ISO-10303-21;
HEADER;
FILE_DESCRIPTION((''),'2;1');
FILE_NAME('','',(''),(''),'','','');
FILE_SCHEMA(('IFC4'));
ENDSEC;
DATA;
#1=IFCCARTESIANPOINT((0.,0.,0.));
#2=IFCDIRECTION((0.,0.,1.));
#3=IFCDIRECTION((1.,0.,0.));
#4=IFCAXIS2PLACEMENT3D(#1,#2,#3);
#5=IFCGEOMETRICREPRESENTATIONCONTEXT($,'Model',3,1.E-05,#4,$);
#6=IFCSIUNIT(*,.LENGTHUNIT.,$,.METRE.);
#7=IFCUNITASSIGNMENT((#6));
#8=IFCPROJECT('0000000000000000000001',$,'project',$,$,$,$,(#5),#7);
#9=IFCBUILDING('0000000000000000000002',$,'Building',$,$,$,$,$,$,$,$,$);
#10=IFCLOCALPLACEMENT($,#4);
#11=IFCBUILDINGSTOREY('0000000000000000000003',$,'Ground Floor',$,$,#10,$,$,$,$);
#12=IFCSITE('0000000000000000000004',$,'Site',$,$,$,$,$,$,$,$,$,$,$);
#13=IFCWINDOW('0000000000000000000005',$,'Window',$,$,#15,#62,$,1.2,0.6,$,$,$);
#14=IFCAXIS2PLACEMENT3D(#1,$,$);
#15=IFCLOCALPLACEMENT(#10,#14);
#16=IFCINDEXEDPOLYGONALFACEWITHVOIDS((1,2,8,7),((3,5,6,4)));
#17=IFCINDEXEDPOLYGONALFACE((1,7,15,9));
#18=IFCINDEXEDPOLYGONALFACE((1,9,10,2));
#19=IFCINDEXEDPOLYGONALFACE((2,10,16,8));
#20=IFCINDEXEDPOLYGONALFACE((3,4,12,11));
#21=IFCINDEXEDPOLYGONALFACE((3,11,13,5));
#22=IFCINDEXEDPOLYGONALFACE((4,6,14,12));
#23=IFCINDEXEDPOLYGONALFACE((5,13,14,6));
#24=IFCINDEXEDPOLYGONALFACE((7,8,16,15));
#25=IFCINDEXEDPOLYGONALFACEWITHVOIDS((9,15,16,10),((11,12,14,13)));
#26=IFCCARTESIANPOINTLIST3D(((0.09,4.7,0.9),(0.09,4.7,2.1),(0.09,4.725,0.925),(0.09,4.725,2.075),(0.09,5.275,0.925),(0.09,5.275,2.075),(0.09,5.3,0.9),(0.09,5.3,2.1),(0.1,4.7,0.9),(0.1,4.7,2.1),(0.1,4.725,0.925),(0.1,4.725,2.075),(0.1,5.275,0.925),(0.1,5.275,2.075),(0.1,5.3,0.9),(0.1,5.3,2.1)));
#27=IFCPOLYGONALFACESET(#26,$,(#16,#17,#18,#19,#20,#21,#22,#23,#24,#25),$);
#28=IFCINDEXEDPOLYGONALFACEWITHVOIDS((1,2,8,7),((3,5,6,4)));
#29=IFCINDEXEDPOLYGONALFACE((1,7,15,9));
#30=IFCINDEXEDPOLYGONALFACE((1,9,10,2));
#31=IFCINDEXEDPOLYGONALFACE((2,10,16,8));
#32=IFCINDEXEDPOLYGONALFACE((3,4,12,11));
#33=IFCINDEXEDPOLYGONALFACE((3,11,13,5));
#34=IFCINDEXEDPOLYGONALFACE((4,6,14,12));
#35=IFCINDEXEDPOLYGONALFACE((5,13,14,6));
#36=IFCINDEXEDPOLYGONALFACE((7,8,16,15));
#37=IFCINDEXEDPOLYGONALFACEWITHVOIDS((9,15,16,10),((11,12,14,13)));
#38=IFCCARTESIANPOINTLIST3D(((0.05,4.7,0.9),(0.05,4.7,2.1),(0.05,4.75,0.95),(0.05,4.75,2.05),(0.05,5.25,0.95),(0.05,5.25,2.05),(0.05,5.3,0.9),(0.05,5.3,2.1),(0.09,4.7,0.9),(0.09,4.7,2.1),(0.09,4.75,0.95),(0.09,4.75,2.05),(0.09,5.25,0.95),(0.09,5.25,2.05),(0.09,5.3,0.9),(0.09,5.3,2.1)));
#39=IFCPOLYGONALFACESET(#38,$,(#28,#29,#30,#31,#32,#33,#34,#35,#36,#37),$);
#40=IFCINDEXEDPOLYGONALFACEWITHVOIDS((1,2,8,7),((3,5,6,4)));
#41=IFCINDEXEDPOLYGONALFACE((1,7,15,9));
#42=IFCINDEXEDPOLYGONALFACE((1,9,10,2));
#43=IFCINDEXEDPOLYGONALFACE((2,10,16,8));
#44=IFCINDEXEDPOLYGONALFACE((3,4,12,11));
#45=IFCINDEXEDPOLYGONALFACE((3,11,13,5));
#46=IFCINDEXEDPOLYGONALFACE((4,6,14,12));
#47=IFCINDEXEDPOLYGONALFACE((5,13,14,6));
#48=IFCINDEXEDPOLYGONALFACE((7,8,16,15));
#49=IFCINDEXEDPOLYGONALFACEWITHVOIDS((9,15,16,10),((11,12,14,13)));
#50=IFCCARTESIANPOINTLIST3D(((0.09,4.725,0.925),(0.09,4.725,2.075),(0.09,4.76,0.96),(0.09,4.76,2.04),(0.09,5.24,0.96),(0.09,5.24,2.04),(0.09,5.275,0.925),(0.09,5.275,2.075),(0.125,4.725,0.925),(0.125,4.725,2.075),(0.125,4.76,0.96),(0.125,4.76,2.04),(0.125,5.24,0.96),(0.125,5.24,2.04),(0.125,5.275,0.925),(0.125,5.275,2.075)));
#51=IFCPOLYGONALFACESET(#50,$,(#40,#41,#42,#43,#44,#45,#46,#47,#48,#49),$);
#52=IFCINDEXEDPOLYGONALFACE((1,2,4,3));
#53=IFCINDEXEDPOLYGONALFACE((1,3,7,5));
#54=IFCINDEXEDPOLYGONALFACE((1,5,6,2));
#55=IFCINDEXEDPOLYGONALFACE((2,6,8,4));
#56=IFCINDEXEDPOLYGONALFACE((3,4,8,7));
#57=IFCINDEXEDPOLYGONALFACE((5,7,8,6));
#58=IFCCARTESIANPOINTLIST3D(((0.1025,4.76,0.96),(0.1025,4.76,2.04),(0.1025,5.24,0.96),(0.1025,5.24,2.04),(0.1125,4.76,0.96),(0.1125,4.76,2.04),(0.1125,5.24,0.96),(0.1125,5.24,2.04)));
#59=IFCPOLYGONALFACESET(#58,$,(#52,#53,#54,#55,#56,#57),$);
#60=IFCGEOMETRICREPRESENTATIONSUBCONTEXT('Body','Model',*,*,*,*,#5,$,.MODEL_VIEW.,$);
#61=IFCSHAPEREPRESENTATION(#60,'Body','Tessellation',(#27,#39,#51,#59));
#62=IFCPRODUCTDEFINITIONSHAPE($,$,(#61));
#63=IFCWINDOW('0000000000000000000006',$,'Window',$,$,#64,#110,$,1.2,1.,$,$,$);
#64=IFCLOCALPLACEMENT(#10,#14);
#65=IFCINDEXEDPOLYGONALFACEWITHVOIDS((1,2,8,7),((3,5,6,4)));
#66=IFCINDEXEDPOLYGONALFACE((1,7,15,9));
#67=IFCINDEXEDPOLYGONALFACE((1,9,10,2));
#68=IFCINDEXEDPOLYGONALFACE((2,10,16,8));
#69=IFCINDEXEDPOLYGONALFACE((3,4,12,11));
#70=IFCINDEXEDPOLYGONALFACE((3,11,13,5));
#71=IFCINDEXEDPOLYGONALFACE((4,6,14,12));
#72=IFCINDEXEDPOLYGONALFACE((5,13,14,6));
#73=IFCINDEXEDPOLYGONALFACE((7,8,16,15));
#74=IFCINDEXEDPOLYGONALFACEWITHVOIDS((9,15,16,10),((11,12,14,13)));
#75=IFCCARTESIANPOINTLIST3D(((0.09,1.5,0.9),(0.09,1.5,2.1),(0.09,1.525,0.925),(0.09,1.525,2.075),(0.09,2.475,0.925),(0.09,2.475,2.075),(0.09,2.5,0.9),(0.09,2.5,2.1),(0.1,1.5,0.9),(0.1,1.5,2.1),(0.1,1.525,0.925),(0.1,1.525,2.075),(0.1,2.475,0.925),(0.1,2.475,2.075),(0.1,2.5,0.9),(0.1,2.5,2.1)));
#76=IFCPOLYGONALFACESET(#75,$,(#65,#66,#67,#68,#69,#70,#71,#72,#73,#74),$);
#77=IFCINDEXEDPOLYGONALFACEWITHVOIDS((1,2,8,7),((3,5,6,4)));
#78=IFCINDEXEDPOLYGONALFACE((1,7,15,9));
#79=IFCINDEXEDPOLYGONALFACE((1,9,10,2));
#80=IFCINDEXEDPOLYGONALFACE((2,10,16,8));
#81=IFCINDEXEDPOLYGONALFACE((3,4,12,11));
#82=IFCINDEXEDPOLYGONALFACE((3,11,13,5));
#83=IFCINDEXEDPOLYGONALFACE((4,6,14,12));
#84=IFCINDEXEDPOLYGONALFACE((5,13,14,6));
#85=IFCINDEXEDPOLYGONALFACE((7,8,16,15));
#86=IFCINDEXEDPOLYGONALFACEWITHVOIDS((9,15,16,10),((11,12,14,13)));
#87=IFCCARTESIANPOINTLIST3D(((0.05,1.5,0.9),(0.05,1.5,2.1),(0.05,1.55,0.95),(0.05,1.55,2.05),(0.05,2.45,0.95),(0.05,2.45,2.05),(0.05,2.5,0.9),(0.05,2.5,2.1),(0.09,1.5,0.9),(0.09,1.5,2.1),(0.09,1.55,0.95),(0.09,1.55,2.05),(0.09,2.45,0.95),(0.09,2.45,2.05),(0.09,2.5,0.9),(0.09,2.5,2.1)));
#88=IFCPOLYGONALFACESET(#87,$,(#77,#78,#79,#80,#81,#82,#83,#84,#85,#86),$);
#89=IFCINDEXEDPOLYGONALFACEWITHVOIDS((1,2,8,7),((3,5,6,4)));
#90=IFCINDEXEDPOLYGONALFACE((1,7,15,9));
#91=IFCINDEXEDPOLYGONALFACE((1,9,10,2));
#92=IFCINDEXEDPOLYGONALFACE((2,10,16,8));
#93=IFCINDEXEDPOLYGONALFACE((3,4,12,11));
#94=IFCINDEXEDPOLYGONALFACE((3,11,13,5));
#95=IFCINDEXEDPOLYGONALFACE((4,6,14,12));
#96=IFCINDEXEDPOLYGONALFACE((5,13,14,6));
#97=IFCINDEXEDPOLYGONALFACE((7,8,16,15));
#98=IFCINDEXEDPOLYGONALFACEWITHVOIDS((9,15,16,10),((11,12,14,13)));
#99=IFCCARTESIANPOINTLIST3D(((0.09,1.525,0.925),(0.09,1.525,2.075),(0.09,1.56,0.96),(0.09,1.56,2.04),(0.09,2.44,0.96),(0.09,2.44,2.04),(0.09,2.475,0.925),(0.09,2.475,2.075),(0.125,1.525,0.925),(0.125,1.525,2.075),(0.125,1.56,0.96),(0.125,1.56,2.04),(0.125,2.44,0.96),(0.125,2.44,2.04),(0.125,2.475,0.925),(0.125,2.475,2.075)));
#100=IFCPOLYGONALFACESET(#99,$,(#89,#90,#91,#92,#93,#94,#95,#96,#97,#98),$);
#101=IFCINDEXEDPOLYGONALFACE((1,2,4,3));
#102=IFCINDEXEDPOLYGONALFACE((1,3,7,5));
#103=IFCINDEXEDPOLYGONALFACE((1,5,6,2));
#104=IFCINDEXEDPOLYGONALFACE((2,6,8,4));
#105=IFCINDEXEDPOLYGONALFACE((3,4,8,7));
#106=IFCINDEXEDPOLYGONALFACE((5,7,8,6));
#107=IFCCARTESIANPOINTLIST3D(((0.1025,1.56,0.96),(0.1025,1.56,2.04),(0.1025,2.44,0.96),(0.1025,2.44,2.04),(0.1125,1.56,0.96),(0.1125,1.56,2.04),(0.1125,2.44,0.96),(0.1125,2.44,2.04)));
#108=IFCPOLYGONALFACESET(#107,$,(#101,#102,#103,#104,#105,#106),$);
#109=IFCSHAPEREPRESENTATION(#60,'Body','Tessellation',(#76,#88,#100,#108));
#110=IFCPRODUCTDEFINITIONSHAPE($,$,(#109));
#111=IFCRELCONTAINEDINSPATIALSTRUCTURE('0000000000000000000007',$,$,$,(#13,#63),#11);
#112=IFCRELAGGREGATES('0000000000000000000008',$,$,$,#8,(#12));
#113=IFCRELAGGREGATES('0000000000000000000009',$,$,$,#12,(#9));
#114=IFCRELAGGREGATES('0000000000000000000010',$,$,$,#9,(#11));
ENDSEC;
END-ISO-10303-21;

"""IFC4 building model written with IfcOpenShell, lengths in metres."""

from ifc_helpers import new_model, si_unit, frame, origin_with_axes, place, context, subcontext, project, spatial, line, indexed_curve, outline, extrude, element, save


model = new_model("IFC4")

# Units and contexts
model_context = context("Model", 3, precision=1e-05, world=origin_with_axes())
body_context = subcontext(model_context, "Body", "Model", "MODEL_VIEW")
ifc_project = project(units=[si_unit("LENGTHUNIT", "METRE")], contexts=[model_context])

# Site, building, storey
site = spatial("IfcSite", under=ifc_project, Name="Site")
building = spatial("IfcBuilding", under=site, Name="Building")
storey_placement = place(None, origin_with_axes())
storey = spatial("IfcBuildingStorey", under=building, at=storey_placement, Name="Ground Floor")

# Windows
window_1_placement = place(storey_placement, frame((0.0, 5.3, 0.9), z_axis=(0.0, 0.0, 1.0), x_axis=(0.0, -1.0, 0.0)))
element("IfcWindow", 1, at=window_1_placement, inside=storey, Name="Window", OverallHeight=1.2, OverallWidth=0.6, context=body_context, shape_type="SweptSolid", body=[
    extrude(outline(indexed_curve([(0.0, 0.0), (0.6, 0.0), (0.6, 1.2), (0.0, 1.2)], segments=[line(1, 2, 3, 4, 1)]), holes=[indexed_curve([(0.025, 0.025), (0.575, 0.025), (0.575, 1.175), (0.025, 1.175)], segments=[line(1, 2, 3, 4, 1)])]), frame((0.0, 0.09, 0.0), z_axis=(0.0, -1.0, 0.0), x_axis=(1.0, 0.0, 0.0)), (0.0, 0.0, -1.0), 0.01),
    extrude(outline(indexed_curve([(0.0, 0.0), (0.6, 0.0), (0.6, 1.2), (0.0, 1.2)], segments=[line(1, 2, 3, 4, 1)]), holes=[indexed_curve([(0.05, 0.05), (0.55, 0.05), (0.55, 1.15), (0.05, 1.15)], segments=[line(1, 2, 3, 4, 1)])]), frame((0.0, 0.05, 0.0), z_axis=(0.0, -1.0, 0.0), x_axis=(1.0, 0.0, 0.0)), (0.0, 0.0, -1.0), 0.04),
    extrude(outline(indexed_curve([(0.0, 0.0), (0.55, 0.0), (0.55, 1.15), (0.0, 1.15)], segments=[line(1, 2, 3, 4, 1)]), holes=[indexed_curve([(0.035, 0.035), (0.515, 0.035), (0.515, 1.115), (0.035, 1.115)], segments=[line(1, 2, 3, 4, 1)])]), frame((0.025, 0.09, 0.025), z_axis=(0.0, -1.0, 0.0), x_axis=(1.0, 0.0, 0.0)), (0.0, 0.0, -1.0), 0.035),
    extrude(outline(indexed_curve([(0.035, 0.035), (0.515, 0.035), (0.515, 1.115), (0.035, 1.115)], segments=[line(1, 2, 3, 4, 1)])), frame((0.025, 0.1025, 0.025), z_axis=(0.0, -1.0, 0.0), x_axis=(1.0, 0.0, 0.0)), (0.0, 0.0, -1.0), 0.01),
])
window_2_placement = place(storey_placement, frame((0.0, 2.5, 0.9), z_axis=(0.0, 0.0, 1.0), x_axis=(0.0, -1.0, 0.0)))
element("IfcWindow", 2, at=window_2_placement, inside=storey, Name="Window", OverallHeight=1.2, OverallWidth=1.0, context=body_context, shape_type="SweptSolid", body=[
    extrude(outline(indexed_curve([(0.0, 0.0), (1.0, 0.0), (1.0, 1.2), (0.0, 1.2)], segments=[line(1, 2, 3, 4, 1)]), holes=[indexed_curve([(0.025, 0.025), (0.975, 0.025), (0.975, 1.175), (0.025, 1.175)], segments=[line(1, 2, 3, 4, 1)])]), frame((0.0, 0.09, 0.0), z_axis=(0.0, -1.0, 0.0), x_axis=(1.0, 0.0, 0.0)), (0.0, 0.0, -1.0), 0.01),
    extrude(outline(indexed_curve([(0.0, 0.0), (1.0, 0.0), (1.0, 1.2), (0.0, 1.2)], segments=[line(1, 2, 3, 4, 1)]), holes=[indexed_curve([(0.05, 0.05), (0.95, 0.05), (0.95, 1.15), (0.05, 1.15)], segments=[line(1, 2, 3, 4, 1)])]), frame((0.0, 0.05, 0.0), z_axis=(0.0, -1.0, 0.0), x_axis=(1.0, 0.0, 0.0)), (0.0, 0.0, -1.0), 0.04),
    extrude(outline(indexed_curve([(0.0, 0.0), (0.95, 0.0), (0.95, 1.15), (0.0, 1.15)], segments=[line(1, 2, 3, 4, 1)]), holes=[indexed_curve([(0.035, 0.035), (0.915, 0.035), (0.915, 1.115), (0.035, 1.115)], segments=[line(1, 2, 3, 4, 1)])]), frame((0.025, 0.09, 0.025), z_axis=(0.0, -1.0, 0.0), x_axis=(1.0, 0.0, 0.0)), (0.0, 0.0, -1.0), 0.035),
    extrude(outline(indexed_curve([(0.035, 0.035), (0.915, 0.035), (0.915, 1.115), (0.035, 1.115)], segments=[line(1, 2, 3, 4, 1)])), frame((0.025, 0.1025, 0.025), z_axis=(0.0, -1.0, 0.0), x_axis=(1.0, 0.0, 0.0)), (0.0, 0.0, -1.0), 0.01),
])

save(model, "model.ifc")
